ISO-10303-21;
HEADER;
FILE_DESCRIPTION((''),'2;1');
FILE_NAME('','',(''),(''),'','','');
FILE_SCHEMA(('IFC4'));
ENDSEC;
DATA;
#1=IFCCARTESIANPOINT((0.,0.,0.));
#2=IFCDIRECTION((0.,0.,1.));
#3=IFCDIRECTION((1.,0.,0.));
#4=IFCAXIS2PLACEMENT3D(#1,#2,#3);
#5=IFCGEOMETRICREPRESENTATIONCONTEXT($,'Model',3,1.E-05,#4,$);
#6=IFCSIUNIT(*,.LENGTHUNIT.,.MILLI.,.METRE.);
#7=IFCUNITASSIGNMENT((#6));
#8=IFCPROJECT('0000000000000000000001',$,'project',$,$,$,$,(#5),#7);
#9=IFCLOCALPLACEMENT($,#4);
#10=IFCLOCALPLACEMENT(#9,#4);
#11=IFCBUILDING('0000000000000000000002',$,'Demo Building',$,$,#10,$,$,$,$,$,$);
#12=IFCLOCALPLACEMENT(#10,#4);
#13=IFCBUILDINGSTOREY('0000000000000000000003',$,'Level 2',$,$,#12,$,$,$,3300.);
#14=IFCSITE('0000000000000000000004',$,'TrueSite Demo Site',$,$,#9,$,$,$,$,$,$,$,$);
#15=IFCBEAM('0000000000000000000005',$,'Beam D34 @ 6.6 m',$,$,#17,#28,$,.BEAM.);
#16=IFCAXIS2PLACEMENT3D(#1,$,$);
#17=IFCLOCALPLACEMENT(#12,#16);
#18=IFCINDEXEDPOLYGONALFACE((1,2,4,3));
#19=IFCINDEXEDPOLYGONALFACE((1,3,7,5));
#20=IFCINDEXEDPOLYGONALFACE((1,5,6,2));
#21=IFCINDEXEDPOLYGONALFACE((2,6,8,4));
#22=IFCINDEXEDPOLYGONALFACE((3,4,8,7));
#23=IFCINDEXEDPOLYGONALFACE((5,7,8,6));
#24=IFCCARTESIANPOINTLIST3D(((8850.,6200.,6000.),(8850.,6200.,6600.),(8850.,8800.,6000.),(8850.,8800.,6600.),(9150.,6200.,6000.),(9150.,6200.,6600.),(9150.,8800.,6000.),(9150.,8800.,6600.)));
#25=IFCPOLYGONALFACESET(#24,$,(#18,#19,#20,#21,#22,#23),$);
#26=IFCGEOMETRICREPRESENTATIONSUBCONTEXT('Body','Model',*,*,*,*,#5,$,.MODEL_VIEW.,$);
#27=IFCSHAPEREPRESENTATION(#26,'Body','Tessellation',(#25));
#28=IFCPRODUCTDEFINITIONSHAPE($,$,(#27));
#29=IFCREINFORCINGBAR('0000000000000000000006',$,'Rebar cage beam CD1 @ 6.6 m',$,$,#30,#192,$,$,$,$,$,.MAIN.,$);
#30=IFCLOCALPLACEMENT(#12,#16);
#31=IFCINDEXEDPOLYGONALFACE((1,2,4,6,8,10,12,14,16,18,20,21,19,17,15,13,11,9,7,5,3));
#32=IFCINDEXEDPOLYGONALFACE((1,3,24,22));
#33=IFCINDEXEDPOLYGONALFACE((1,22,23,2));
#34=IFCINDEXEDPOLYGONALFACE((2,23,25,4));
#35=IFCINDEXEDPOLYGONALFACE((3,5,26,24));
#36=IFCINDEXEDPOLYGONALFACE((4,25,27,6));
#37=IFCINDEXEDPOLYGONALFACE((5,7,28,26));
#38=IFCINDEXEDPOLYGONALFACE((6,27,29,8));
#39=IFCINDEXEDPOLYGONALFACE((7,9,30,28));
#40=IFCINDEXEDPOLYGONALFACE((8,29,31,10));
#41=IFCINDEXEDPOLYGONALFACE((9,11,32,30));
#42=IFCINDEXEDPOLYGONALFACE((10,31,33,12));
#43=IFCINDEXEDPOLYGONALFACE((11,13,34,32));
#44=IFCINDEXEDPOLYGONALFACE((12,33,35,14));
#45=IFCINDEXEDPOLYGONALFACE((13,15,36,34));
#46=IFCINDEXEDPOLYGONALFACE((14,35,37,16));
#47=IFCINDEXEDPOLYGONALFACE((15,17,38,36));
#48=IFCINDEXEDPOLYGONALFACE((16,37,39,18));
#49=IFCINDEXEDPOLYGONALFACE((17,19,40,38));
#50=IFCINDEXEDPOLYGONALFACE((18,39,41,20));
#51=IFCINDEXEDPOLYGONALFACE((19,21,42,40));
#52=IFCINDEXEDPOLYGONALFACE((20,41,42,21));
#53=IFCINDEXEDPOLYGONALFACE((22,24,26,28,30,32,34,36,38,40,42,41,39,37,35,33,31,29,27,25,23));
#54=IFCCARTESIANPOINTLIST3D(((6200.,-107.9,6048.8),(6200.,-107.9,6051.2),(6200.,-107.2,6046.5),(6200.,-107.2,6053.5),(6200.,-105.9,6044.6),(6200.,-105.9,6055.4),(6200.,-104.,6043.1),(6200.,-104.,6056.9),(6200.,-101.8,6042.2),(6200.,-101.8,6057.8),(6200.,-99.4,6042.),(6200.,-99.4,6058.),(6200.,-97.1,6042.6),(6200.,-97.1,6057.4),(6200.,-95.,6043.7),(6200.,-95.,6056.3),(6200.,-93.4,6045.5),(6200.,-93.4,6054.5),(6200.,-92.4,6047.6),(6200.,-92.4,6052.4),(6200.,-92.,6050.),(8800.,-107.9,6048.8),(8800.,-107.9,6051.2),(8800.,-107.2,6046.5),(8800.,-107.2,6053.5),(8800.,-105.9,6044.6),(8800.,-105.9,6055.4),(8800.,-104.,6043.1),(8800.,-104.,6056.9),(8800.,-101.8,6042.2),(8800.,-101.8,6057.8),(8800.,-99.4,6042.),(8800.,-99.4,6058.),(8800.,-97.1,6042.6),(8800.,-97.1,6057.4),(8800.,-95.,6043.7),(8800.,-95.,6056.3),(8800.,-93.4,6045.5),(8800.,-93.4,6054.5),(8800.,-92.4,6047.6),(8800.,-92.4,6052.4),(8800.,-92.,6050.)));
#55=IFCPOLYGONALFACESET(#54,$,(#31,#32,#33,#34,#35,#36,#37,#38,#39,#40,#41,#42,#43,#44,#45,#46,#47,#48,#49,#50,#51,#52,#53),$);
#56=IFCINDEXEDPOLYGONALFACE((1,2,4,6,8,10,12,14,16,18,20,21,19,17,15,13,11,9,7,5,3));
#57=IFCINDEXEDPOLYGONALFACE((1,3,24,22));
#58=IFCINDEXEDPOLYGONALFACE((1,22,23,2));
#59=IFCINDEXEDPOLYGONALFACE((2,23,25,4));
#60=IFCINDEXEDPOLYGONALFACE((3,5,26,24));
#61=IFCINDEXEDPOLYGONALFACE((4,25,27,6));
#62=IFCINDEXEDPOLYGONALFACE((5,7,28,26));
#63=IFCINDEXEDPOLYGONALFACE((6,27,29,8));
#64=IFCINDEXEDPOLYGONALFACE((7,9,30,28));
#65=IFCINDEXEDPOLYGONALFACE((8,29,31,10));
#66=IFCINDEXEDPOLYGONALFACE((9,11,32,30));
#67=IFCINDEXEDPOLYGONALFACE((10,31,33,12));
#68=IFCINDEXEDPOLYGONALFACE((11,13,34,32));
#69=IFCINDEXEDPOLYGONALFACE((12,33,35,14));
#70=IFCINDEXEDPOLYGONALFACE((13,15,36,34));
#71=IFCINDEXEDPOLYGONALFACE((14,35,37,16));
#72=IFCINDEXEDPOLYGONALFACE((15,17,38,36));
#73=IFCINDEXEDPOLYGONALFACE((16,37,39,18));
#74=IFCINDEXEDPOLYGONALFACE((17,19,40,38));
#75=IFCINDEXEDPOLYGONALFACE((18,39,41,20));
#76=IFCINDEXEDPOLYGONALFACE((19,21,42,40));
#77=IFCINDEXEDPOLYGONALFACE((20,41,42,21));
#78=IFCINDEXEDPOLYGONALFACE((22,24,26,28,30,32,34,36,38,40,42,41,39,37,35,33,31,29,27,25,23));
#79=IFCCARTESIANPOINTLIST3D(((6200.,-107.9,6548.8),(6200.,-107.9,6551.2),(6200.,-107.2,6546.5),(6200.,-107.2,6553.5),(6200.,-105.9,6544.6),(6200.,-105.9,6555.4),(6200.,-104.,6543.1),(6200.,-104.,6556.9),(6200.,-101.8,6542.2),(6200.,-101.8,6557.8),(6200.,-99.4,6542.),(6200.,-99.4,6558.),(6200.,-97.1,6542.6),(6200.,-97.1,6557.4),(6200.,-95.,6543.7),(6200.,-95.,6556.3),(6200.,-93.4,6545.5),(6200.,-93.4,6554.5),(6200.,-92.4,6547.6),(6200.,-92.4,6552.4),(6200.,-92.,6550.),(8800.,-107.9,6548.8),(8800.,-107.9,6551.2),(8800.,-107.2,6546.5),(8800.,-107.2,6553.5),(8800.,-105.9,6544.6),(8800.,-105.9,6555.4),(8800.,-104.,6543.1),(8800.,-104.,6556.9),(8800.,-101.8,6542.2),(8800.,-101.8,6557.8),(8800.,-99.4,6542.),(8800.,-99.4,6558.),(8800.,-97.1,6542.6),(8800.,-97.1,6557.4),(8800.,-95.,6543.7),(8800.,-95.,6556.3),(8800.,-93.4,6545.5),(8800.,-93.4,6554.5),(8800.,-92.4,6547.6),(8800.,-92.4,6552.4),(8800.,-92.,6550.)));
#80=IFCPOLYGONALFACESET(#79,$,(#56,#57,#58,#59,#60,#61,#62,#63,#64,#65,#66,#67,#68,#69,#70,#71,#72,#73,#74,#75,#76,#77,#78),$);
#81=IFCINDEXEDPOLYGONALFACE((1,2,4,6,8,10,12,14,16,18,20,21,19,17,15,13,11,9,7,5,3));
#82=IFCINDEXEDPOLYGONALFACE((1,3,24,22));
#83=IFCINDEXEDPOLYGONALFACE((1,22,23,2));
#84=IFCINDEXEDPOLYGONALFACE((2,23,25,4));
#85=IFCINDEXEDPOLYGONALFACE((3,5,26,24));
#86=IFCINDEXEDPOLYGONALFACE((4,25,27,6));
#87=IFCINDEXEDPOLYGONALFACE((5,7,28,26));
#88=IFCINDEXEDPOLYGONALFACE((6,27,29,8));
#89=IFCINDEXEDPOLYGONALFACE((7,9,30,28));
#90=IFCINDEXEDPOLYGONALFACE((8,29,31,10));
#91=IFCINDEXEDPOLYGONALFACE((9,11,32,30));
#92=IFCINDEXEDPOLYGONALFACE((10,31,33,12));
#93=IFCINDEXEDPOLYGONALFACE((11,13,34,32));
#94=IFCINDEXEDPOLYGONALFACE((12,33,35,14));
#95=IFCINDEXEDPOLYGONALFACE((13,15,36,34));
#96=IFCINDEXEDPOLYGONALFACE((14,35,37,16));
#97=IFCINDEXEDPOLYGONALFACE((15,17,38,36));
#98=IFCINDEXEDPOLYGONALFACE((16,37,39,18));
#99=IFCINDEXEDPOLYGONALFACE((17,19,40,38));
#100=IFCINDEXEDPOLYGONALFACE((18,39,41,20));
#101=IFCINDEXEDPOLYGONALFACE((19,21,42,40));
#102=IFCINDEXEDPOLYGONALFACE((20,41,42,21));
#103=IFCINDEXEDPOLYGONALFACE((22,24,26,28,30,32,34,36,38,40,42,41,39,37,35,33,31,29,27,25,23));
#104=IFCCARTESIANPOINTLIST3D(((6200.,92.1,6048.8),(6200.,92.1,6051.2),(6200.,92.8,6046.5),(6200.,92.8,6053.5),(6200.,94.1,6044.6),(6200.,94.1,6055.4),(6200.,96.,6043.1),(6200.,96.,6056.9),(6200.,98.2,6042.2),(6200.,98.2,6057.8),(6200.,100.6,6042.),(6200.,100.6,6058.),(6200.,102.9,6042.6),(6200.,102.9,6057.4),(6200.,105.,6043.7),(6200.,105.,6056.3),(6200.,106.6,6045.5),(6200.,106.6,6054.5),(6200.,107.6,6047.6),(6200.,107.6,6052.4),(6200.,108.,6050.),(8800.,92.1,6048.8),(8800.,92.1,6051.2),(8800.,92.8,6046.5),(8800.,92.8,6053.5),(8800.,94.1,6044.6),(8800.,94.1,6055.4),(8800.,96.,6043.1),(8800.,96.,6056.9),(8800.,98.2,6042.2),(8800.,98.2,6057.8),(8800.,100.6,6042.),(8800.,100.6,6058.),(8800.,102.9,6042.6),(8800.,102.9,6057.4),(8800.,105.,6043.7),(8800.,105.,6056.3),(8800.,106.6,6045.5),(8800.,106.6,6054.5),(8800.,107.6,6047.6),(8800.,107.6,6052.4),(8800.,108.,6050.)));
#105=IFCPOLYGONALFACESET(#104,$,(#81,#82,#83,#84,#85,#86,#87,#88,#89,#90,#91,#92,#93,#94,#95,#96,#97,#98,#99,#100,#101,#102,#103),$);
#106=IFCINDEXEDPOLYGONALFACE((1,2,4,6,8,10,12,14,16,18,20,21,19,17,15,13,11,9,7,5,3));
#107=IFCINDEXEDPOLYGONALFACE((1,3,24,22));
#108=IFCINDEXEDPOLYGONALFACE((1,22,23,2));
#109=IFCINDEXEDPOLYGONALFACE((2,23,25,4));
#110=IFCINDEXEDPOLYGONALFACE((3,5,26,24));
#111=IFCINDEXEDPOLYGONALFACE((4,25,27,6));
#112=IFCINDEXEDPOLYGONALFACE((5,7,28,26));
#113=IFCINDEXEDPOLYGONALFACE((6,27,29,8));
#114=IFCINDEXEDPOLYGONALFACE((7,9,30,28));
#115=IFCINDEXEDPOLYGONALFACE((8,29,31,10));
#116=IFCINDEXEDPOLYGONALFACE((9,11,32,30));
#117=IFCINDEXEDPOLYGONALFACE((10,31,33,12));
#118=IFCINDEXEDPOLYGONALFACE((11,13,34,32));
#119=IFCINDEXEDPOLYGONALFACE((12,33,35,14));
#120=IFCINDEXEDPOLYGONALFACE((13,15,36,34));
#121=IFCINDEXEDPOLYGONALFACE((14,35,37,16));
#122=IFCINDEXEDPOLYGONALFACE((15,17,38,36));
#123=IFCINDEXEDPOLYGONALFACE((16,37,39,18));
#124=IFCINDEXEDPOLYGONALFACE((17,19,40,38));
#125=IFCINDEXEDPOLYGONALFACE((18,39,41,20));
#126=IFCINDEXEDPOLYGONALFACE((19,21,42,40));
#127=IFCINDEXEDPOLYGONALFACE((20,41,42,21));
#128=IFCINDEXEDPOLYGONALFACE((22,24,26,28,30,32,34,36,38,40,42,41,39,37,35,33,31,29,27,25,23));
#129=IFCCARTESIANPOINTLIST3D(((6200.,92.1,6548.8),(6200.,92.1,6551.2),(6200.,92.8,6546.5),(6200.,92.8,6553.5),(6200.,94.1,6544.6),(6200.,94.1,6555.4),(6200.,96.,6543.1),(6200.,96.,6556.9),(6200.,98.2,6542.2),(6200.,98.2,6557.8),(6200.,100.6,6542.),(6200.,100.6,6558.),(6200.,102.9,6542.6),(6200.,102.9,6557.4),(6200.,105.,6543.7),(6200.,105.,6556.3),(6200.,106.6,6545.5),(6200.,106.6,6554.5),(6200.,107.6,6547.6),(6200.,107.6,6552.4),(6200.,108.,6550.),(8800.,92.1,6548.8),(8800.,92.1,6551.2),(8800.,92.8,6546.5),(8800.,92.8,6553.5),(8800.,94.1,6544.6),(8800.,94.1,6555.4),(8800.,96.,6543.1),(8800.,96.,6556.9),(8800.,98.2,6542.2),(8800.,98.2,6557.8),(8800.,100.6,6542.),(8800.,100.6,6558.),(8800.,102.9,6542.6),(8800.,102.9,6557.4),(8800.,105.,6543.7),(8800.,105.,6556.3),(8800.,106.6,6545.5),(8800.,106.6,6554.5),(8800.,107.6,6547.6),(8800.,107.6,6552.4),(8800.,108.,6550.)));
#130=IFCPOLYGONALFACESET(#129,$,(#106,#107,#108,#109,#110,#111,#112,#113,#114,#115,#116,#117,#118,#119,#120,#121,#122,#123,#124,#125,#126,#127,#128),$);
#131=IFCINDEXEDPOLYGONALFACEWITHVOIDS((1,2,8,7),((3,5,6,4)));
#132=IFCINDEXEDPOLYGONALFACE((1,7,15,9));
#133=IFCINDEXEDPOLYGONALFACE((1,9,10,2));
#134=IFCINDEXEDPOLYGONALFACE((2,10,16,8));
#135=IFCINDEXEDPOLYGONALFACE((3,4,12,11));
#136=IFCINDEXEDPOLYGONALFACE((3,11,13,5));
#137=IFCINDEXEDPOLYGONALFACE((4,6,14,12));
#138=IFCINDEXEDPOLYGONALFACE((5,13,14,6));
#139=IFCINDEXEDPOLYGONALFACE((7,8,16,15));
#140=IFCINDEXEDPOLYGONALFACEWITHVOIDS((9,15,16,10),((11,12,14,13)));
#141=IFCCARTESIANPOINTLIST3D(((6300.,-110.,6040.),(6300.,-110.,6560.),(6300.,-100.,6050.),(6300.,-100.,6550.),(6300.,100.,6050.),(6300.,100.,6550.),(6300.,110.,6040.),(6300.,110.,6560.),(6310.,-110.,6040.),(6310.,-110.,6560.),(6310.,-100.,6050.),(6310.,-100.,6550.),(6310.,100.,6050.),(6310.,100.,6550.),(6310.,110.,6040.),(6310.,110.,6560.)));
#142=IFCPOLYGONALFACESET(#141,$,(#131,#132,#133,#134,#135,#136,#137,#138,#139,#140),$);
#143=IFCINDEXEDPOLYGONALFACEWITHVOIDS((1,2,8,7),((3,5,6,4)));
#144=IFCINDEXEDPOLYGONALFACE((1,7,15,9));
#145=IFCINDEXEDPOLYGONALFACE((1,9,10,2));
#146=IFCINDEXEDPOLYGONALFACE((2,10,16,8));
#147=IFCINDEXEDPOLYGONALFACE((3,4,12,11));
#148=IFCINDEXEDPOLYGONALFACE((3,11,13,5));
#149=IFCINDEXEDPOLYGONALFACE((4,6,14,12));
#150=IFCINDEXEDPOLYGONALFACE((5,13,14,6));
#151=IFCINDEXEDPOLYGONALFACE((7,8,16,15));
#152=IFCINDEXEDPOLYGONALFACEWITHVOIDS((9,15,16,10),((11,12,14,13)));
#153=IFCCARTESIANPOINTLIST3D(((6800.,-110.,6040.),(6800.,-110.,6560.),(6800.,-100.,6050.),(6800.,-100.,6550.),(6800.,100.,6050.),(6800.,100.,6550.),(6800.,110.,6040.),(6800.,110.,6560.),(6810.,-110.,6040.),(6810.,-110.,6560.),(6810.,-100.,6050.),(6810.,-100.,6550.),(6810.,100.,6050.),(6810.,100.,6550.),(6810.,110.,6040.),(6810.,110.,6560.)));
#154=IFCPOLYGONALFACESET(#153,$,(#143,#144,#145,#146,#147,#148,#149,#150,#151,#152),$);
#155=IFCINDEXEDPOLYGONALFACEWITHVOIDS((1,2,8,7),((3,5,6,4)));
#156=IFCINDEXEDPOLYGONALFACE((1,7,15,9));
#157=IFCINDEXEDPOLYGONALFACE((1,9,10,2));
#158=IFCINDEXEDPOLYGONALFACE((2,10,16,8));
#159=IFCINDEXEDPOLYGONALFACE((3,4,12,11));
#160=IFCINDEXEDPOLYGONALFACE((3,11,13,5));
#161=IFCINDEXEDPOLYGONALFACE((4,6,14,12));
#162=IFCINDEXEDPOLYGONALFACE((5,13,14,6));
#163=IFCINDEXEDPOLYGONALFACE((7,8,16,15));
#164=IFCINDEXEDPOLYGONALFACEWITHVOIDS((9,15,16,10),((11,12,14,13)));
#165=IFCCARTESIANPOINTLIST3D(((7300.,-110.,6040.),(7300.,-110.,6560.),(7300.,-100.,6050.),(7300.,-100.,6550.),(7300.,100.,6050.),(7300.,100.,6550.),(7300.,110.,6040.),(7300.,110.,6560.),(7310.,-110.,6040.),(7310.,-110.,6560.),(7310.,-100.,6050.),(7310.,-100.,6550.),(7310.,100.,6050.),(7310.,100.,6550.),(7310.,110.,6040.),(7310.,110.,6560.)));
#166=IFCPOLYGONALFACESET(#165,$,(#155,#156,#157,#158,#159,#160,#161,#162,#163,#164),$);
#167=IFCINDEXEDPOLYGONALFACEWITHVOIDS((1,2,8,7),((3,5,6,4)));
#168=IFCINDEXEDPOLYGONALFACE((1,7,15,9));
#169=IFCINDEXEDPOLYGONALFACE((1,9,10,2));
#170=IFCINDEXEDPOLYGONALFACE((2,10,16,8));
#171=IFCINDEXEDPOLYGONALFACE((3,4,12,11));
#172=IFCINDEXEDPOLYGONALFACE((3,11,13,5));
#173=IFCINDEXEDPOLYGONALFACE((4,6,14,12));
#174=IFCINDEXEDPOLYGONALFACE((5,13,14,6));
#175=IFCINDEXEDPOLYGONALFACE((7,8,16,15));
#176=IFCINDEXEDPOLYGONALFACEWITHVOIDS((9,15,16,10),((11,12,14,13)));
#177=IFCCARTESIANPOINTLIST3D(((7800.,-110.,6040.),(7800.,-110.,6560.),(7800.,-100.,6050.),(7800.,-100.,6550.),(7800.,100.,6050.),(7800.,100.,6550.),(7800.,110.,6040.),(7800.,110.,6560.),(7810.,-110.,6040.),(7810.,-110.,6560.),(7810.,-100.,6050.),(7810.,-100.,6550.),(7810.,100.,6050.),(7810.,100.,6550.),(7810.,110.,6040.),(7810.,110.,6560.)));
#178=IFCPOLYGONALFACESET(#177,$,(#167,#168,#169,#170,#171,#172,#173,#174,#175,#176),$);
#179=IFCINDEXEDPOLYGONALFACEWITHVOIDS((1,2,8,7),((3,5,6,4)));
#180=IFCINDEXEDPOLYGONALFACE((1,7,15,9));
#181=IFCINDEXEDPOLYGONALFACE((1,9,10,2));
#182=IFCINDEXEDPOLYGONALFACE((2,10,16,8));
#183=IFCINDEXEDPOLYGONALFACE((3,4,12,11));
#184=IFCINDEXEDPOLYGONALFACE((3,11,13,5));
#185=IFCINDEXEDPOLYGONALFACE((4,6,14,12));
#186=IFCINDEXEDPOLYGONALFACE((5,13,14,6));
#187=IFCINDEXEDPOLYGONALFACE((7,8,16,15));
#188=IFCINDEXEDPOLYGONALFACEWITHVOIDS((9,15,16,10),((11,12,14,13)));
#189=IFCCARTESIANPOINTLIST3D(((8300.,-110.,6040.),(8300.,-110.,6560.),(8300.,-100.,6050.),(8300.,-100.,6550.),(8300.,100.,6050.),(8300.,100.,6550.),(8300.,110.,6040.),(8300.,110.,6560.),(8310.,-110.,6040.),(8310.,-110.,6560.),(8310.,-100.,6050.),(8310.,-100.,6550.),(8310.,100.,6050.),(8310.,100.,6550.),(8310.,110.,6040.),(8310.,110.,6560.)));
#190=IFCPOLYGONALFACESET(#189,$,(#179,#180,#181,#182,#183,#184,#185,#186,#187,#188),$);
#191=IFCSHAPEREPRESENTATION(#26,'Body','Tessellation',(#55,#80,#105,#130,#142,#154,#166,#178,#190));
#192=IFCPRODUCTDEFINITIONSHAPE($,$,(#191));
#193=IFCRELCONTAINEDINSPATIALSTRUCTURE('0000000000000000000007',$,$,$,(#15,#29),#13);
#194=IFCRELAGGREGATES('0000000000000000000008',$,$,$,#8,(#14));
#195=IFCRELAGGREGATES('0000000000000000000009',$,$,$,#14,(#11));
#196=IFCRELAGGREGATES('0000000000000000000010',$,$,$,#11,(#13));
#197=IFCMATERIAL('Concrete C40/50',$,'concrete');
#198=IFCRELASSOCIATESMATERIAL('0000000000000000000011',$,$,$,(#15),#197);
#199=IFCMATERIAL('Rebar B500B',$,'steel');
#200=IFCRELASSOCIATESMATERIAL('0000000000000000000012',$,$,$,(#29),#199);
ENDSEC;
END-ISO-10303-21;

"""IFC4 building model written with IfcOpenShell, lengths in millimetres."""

from ifc_helpers import new_model, si_unit, frame, origin_with_axes, place, context, subcontext, project, spatial, rectangle, hollow_rectangle, circle, extrude, material, element, save


model = new_model("IFC4")

# Units and contexts
model_context = context("Model", 3, precision=1e-05, world=origin_with_axes())
body_context = subcontext(model_context, "Body", "Model", "MODEL_VIEW")
ifc_project = project(units=[si_unit("LENGTHUNIT", "METRE", prefix="MILLI")], contexts=[model_context])

# Site, building, storey
site_placement = place(None, origin_with_axes())
site = spatial("IfcSite", under=ifc_project, at=site_placement, Name="TrueSite Demo Site")
building_placement = place(site_placement, origin_with_axes())
building = spatial("IfcBuilding", under=site, at=building_placement, Name="Demo Building")
storey_placement = place(building_placement, origin_with_axes())
storey = spatial("IfcBuildingStorey", under=building, at=storey_placement, Name="Level 2", Elevation=3300.0)

# Shared definitions
ifc_material_1 = material(Name="Concrete C40/50", Category="concrete")

# Beam
for number, where, z_axis, x_axis, name in (
    (1, (9000.0, 6200.0, 6300.0), (0.0, 1.0, 0.0), (1.0, 0.0, 0.0), "Beam D34 @ 6.6 m"),
):
    element("IfcBeam", number, at=place(storey_placement, frame(where, z_axis=z_axis, x_axis=x_axis)), inside=storey, material=ifc_material_1, Name=name, PredefinedType="BEAM", context=body_context, shape_type="SweptSolid", body=[
        extrude(rectangle(XDim=300.0, YDim=600.0), origin_with_axes(), (0.0, 0.0, 1.0), 2600.0),
    ])

# Reinforcing bar
ifc_material_2 = material(Name="Rebar B500B", Category="steel")
for number, where, z_axis, x_axis, name in (
    (2, (6200.0, 0.0, 6300.0), (1.0, 0.0, 0.0), (0.0, 1.0, 0.0), "Rebar cage beam CD1 @ 6.6 m"),
):
    element("IfcReinforcingBar", number, at=place(storey_placement, frame(where, z_axis=z_axis, x_axis=x_axis)), inside=storey, material=ifc_material_2, Name=name, PredefinedType="MAIN", context=body_context, shape_type="SweptSolid", body=[
        extrude(circle(Radius=8.0), frame((-100.0, -250.0, 0.0)), (0.0, 0.0, 1.0), 2600.0),
        extrude(circle(Radius=8.0), frame((-100.0, 250.0, 0.0)), (0.0, 0.0, 1.0), 2600.0),
        extrude(circle(Radius=8.0), frame((100.0, -250.0, 0.0)), (0.0, 0.0, 1.0), 2600.0),
        extrude(circle(Radius=8.0), frame((100.0, 250.0, 0.0)), (0.0, 0.0, 1.0), 2600.0),
        extrude(hollow_rectangle(XDim=220.0, YDim=520.0, WallThickness=10.0), frame((0.0, 0.0, 100.0)), (0.0, 0.0, 1.0), 10.0),
        extrude(hollow_rectangle(XDim=220.0, YDim=520.0, WallThickness=10.0), frame((0.0, 0.0, 600.0)), (0.0, 0.0, 1.0), 10.0),
        extrude(hollow_rectangle(XDim=220.0, YDim=520.0, WallThickness=10.0), frame((0.0, 0.0, 1100.0)), (0.0, 0.0, 1.0), 10.0),
        extrude(hollow_rectangle(XDim=220.0, YDim=520.0, WallThickness=10.0), frame((0.0, 0.0, 1600.0)), (0.0, 0.0, 1.0), 10.0),
        extrude(hollow_rectangle(XDim=220.0, YDim=520.0, WallThickness=10.0), frame((0.0, 0.0, 2100.0)), (0.0, 0.0, 1.0), 10.0),
    ])

save(model, "model.ifc")
